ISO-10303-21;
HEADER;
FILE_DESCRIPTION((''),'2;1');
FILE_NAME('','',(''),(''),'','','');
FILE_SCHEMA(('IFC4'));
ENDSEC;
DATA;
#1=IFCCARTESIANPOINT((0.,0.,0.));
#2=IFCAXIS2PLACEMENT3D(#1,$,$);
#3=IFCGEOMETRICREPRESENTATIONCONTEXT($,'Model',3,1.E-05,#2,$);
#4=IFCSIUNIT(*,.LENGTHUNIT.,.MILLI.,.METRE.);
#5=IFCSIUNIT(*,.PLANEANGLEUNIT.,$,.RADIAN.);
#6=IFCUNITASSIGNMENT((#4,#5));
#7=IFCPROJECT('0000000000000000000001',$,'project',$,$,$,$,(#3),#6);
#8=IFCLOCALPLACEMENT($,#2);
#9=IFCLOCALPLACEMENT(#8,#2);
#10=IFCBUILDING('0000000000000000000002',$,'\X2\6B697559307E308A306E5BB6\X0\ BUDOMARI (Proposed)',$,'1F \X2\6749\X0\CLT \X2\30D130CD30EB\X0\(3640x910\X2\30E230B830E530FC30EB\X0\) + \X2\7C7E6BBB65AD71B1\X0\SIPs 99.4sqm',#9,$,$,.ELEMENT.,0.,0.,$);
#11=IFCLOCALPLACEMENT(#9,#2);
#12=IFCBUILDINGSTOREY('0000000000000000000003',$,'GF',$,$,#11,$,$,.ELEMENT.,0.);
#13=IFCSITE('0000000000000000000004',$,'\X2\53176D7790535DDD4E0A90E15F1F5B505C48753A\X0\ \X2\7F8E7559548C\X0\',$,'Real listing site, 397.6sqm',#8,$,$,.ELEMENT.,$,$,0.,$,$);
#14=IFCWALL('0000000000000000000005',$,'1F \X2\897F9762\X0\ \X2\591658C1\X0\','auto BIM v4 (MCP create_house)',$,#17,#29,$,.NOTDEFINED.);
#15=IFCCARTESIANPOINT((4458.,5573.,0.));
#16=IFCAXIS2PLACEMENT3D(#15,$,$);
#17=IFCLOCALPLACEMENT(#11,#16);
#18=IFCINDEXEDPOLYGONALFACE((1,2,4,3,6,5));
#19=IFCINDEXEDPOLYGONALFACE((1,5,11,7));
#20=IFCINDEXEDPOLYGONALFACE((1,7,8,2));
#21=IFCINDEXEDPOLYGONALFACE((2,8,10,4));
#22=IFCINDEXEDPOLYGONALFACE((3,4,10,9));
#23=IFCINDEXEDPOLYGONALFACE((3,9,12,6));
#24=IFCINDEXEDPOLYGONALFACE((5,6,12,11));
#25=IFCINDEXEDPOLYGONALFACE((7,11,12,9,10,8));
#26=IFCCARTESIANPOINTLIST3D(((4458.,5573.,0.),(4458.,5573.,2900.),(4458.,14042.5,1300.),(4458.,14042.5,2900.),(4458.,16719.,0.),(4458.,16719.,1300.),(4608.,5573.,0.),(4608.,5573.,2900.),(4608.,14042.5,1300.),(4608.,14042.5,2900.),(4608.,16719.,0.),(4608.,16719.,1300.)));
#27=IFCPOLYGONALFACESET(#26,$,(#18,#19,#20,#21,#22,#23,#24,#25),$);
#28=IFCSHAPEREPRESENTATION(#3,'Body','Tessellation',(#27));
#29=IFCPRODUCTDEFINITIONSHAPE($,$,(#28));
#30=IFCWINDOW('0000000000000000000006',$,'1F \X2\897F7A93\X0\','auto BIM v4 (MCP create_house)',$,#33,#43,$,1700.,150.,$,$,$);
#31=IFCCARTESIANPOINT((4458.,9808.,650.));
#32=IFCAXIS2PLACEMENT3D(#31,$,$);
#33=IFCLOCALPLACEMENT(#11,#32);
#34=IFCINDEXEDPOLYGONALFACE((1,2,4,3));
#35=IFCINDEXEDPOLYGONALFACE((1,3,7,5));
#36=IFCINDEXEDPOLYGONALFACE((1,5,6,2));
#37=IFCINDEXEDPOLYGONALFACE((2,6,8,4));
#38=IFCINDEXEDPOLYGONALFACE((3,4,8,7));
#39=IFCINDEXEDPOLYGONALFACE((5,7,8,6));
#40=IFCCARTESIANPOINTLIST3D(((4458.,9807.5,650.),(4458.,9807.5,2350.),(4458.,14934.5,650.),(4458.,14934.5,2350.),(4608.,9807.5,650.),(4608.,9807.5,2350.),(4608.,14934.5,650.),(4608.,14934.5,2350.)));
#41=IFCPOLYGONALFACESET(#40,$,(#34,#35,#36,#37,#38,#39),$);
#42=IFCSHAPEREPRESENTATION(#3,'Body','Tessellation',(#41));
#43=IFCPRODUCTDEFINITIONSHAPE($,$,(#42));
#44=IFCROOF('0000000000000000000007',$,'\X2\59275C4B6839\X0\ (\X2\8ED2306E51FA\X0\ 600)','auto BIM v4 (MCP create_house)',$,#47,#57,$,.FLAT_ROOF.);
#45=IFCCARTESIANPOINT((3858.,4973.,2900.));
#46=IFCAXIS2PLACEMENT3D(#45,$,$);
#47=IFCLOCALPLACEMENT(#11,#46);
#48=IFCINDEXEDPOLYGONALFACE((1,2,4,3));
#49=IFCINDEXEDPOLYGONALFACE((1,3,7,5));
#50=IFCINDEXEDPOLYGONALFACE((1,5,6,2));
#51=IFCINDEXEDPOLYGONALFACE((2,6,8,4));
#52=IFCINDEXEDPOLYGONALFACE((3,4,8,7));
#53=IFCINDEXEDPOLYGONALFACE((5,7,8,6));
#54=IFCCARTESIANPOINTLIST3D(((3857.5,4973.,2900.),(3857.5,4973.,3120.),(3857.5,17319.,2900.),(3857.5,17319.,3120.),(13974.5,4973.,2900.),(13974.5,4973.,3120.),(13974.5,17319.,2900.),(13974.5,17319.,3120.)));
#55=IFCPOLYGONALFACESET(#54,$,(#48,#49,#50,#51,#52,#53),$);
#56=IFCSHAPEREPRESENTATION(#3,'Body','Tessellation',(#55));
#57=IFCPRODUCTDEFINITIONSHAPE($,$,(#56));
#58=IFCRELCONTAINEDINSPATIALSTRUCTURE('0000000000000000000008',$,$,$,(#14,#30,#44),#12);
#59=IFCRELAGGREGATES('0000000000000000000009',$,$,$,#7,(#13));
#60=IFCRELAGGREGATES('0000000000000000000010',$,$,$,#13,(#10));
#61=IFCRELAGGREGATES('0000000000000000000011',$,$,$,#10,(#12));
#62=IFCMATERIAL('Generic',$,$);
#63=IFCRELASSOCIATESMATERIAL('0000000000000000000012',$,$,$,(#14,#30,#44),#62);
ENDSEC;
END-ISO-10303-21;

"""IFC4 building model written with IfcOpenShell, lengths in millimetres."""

from ifc_helpers import new_model, si_unit, frame, frame_2d, origin, place, context, project, spatial, rectangle, extrude, material, element, fill, save


model = new_model("IFC4")

# Units and contexts
model_context = context("Model", 3, precision=1e-05, world=origin())
ifc_project = project(units=[si_unit("LENGTHUNIT", "METRE", prefix="MILLI"), si_unit("PLANEANGLEUNIT", "RADIAN")], contexts=[model_context])

# Site, building, storey
site_placement = place(None, origin())
site = spatial("IfcSite", under=ifc_project, at=site_placement, Name="北海道川上郡弟子屈町 美留和", ObjectType="Real listing site, 397.6sqm", CompositionType="ELEMENT", RefElevation=0.0)
building_placement = place(site_placement, origin())
building = spatial("IfcBuilding", under=site, at=building_placement, Name="歩留まりの家 BUDOMARI (Proposed)", ObjectType="1F 杉CLT パネル(3640x910モジュール) + 籾殻断熱SIPs 99.4sqm", CompositionType="ELEMENT", ElevationOfRefHeight=0.0, ElevationOfTerrain=0.0)
storey_placement = place(building_placement, origin())
storey = spatial("IfcBuildingStorey", under=building, at=storey_placement, Name="GF", CompositionType="ELEMENT", Elevation=0.0)

# Shared definitions
ifc_material = material(Name="Generic")

# Wall, opening, window
wall_1_placement = place(storey_placement, frame((4458.0, 5573.0, 0.0)))
wall_1 = element("IfcWall", 1, at=wall_1_placement, inside=storey, material=ifc_material, Name="1F 西面 外壁", Description="auto BIM v4 (MCP create_house)", PredefinedType="NOTDEFINED", context=model_context, shape_type="SweptSolid", body=[
    extrude(rectangle(XDim=150.0, YDim=11146.0, at=frame_2d((75.0, 5573.0))), frame((4458.0, 5573.0, 0.0)), (0.0, 0.0, 1.0), 2900.0),
])
opening_1_placement = place(storey_placement, frame((4458.0, 9808.0, 650.0)))
opening_1 = element("IfcOpeningElement", 2, at=opening_1_placement, cuts=wall_1, PredefinedType="NOTDEFINED", context=model_context, shape_type="SweptSolid", body=[
    extrude(rectangle(XDim=150.0, YDim=5127.0, at=frame_2d((75.0, 2563.0))), frame((4458.0, 9808.0, 650.0)), (0.0, 0.0, 1.0), 1700.0),
])
window_1_placement = place(storey_placement, frame((4458.0, 9808.0, 650.0)))
window_1 = element("IfcWindow", 3, at=window_1_placement, inside=storey, material=ifc_material, Name="1F 西窓", Description="auto BIM v4 (MCP create_house)", OverallHeight=1700.0, OverallWidth=150.0, context=model_context, shape_type="SweptSolid", body=[
    extrude(rectangle(XDim=150.0, YDim=5127.0, at=frame_2d((75.0, 2563.0))), frame((4458.0, 9808.0, 650.0)), (0.0, 0.0, 1.0), 1700.0),
])
fill(opening_1, window_1)

# Roof
roof_placement = place(storey_placement, frame((3858.0, 4973.0, 2900.0)))
element("IfcRoof", 4, at=roof_placement, inside=storey, material=ifc_material, Name="大屋根 (軒の出 600)", Description="auto BIM v4 (MCP create_house)", PredefinedType="FLAT_ROOF", context=model_context, shape_type="SweptSolid", body=[
    extrude(rectangle(XDim=10117.0, YDim=12346.0, at=frame_2d((5058.0, 6173.0))), frame((3858.0, 4973.0, 2900.0)), (0.0, 0.0, 1.0), 220.0),
])

save(model, "model.ifc")
